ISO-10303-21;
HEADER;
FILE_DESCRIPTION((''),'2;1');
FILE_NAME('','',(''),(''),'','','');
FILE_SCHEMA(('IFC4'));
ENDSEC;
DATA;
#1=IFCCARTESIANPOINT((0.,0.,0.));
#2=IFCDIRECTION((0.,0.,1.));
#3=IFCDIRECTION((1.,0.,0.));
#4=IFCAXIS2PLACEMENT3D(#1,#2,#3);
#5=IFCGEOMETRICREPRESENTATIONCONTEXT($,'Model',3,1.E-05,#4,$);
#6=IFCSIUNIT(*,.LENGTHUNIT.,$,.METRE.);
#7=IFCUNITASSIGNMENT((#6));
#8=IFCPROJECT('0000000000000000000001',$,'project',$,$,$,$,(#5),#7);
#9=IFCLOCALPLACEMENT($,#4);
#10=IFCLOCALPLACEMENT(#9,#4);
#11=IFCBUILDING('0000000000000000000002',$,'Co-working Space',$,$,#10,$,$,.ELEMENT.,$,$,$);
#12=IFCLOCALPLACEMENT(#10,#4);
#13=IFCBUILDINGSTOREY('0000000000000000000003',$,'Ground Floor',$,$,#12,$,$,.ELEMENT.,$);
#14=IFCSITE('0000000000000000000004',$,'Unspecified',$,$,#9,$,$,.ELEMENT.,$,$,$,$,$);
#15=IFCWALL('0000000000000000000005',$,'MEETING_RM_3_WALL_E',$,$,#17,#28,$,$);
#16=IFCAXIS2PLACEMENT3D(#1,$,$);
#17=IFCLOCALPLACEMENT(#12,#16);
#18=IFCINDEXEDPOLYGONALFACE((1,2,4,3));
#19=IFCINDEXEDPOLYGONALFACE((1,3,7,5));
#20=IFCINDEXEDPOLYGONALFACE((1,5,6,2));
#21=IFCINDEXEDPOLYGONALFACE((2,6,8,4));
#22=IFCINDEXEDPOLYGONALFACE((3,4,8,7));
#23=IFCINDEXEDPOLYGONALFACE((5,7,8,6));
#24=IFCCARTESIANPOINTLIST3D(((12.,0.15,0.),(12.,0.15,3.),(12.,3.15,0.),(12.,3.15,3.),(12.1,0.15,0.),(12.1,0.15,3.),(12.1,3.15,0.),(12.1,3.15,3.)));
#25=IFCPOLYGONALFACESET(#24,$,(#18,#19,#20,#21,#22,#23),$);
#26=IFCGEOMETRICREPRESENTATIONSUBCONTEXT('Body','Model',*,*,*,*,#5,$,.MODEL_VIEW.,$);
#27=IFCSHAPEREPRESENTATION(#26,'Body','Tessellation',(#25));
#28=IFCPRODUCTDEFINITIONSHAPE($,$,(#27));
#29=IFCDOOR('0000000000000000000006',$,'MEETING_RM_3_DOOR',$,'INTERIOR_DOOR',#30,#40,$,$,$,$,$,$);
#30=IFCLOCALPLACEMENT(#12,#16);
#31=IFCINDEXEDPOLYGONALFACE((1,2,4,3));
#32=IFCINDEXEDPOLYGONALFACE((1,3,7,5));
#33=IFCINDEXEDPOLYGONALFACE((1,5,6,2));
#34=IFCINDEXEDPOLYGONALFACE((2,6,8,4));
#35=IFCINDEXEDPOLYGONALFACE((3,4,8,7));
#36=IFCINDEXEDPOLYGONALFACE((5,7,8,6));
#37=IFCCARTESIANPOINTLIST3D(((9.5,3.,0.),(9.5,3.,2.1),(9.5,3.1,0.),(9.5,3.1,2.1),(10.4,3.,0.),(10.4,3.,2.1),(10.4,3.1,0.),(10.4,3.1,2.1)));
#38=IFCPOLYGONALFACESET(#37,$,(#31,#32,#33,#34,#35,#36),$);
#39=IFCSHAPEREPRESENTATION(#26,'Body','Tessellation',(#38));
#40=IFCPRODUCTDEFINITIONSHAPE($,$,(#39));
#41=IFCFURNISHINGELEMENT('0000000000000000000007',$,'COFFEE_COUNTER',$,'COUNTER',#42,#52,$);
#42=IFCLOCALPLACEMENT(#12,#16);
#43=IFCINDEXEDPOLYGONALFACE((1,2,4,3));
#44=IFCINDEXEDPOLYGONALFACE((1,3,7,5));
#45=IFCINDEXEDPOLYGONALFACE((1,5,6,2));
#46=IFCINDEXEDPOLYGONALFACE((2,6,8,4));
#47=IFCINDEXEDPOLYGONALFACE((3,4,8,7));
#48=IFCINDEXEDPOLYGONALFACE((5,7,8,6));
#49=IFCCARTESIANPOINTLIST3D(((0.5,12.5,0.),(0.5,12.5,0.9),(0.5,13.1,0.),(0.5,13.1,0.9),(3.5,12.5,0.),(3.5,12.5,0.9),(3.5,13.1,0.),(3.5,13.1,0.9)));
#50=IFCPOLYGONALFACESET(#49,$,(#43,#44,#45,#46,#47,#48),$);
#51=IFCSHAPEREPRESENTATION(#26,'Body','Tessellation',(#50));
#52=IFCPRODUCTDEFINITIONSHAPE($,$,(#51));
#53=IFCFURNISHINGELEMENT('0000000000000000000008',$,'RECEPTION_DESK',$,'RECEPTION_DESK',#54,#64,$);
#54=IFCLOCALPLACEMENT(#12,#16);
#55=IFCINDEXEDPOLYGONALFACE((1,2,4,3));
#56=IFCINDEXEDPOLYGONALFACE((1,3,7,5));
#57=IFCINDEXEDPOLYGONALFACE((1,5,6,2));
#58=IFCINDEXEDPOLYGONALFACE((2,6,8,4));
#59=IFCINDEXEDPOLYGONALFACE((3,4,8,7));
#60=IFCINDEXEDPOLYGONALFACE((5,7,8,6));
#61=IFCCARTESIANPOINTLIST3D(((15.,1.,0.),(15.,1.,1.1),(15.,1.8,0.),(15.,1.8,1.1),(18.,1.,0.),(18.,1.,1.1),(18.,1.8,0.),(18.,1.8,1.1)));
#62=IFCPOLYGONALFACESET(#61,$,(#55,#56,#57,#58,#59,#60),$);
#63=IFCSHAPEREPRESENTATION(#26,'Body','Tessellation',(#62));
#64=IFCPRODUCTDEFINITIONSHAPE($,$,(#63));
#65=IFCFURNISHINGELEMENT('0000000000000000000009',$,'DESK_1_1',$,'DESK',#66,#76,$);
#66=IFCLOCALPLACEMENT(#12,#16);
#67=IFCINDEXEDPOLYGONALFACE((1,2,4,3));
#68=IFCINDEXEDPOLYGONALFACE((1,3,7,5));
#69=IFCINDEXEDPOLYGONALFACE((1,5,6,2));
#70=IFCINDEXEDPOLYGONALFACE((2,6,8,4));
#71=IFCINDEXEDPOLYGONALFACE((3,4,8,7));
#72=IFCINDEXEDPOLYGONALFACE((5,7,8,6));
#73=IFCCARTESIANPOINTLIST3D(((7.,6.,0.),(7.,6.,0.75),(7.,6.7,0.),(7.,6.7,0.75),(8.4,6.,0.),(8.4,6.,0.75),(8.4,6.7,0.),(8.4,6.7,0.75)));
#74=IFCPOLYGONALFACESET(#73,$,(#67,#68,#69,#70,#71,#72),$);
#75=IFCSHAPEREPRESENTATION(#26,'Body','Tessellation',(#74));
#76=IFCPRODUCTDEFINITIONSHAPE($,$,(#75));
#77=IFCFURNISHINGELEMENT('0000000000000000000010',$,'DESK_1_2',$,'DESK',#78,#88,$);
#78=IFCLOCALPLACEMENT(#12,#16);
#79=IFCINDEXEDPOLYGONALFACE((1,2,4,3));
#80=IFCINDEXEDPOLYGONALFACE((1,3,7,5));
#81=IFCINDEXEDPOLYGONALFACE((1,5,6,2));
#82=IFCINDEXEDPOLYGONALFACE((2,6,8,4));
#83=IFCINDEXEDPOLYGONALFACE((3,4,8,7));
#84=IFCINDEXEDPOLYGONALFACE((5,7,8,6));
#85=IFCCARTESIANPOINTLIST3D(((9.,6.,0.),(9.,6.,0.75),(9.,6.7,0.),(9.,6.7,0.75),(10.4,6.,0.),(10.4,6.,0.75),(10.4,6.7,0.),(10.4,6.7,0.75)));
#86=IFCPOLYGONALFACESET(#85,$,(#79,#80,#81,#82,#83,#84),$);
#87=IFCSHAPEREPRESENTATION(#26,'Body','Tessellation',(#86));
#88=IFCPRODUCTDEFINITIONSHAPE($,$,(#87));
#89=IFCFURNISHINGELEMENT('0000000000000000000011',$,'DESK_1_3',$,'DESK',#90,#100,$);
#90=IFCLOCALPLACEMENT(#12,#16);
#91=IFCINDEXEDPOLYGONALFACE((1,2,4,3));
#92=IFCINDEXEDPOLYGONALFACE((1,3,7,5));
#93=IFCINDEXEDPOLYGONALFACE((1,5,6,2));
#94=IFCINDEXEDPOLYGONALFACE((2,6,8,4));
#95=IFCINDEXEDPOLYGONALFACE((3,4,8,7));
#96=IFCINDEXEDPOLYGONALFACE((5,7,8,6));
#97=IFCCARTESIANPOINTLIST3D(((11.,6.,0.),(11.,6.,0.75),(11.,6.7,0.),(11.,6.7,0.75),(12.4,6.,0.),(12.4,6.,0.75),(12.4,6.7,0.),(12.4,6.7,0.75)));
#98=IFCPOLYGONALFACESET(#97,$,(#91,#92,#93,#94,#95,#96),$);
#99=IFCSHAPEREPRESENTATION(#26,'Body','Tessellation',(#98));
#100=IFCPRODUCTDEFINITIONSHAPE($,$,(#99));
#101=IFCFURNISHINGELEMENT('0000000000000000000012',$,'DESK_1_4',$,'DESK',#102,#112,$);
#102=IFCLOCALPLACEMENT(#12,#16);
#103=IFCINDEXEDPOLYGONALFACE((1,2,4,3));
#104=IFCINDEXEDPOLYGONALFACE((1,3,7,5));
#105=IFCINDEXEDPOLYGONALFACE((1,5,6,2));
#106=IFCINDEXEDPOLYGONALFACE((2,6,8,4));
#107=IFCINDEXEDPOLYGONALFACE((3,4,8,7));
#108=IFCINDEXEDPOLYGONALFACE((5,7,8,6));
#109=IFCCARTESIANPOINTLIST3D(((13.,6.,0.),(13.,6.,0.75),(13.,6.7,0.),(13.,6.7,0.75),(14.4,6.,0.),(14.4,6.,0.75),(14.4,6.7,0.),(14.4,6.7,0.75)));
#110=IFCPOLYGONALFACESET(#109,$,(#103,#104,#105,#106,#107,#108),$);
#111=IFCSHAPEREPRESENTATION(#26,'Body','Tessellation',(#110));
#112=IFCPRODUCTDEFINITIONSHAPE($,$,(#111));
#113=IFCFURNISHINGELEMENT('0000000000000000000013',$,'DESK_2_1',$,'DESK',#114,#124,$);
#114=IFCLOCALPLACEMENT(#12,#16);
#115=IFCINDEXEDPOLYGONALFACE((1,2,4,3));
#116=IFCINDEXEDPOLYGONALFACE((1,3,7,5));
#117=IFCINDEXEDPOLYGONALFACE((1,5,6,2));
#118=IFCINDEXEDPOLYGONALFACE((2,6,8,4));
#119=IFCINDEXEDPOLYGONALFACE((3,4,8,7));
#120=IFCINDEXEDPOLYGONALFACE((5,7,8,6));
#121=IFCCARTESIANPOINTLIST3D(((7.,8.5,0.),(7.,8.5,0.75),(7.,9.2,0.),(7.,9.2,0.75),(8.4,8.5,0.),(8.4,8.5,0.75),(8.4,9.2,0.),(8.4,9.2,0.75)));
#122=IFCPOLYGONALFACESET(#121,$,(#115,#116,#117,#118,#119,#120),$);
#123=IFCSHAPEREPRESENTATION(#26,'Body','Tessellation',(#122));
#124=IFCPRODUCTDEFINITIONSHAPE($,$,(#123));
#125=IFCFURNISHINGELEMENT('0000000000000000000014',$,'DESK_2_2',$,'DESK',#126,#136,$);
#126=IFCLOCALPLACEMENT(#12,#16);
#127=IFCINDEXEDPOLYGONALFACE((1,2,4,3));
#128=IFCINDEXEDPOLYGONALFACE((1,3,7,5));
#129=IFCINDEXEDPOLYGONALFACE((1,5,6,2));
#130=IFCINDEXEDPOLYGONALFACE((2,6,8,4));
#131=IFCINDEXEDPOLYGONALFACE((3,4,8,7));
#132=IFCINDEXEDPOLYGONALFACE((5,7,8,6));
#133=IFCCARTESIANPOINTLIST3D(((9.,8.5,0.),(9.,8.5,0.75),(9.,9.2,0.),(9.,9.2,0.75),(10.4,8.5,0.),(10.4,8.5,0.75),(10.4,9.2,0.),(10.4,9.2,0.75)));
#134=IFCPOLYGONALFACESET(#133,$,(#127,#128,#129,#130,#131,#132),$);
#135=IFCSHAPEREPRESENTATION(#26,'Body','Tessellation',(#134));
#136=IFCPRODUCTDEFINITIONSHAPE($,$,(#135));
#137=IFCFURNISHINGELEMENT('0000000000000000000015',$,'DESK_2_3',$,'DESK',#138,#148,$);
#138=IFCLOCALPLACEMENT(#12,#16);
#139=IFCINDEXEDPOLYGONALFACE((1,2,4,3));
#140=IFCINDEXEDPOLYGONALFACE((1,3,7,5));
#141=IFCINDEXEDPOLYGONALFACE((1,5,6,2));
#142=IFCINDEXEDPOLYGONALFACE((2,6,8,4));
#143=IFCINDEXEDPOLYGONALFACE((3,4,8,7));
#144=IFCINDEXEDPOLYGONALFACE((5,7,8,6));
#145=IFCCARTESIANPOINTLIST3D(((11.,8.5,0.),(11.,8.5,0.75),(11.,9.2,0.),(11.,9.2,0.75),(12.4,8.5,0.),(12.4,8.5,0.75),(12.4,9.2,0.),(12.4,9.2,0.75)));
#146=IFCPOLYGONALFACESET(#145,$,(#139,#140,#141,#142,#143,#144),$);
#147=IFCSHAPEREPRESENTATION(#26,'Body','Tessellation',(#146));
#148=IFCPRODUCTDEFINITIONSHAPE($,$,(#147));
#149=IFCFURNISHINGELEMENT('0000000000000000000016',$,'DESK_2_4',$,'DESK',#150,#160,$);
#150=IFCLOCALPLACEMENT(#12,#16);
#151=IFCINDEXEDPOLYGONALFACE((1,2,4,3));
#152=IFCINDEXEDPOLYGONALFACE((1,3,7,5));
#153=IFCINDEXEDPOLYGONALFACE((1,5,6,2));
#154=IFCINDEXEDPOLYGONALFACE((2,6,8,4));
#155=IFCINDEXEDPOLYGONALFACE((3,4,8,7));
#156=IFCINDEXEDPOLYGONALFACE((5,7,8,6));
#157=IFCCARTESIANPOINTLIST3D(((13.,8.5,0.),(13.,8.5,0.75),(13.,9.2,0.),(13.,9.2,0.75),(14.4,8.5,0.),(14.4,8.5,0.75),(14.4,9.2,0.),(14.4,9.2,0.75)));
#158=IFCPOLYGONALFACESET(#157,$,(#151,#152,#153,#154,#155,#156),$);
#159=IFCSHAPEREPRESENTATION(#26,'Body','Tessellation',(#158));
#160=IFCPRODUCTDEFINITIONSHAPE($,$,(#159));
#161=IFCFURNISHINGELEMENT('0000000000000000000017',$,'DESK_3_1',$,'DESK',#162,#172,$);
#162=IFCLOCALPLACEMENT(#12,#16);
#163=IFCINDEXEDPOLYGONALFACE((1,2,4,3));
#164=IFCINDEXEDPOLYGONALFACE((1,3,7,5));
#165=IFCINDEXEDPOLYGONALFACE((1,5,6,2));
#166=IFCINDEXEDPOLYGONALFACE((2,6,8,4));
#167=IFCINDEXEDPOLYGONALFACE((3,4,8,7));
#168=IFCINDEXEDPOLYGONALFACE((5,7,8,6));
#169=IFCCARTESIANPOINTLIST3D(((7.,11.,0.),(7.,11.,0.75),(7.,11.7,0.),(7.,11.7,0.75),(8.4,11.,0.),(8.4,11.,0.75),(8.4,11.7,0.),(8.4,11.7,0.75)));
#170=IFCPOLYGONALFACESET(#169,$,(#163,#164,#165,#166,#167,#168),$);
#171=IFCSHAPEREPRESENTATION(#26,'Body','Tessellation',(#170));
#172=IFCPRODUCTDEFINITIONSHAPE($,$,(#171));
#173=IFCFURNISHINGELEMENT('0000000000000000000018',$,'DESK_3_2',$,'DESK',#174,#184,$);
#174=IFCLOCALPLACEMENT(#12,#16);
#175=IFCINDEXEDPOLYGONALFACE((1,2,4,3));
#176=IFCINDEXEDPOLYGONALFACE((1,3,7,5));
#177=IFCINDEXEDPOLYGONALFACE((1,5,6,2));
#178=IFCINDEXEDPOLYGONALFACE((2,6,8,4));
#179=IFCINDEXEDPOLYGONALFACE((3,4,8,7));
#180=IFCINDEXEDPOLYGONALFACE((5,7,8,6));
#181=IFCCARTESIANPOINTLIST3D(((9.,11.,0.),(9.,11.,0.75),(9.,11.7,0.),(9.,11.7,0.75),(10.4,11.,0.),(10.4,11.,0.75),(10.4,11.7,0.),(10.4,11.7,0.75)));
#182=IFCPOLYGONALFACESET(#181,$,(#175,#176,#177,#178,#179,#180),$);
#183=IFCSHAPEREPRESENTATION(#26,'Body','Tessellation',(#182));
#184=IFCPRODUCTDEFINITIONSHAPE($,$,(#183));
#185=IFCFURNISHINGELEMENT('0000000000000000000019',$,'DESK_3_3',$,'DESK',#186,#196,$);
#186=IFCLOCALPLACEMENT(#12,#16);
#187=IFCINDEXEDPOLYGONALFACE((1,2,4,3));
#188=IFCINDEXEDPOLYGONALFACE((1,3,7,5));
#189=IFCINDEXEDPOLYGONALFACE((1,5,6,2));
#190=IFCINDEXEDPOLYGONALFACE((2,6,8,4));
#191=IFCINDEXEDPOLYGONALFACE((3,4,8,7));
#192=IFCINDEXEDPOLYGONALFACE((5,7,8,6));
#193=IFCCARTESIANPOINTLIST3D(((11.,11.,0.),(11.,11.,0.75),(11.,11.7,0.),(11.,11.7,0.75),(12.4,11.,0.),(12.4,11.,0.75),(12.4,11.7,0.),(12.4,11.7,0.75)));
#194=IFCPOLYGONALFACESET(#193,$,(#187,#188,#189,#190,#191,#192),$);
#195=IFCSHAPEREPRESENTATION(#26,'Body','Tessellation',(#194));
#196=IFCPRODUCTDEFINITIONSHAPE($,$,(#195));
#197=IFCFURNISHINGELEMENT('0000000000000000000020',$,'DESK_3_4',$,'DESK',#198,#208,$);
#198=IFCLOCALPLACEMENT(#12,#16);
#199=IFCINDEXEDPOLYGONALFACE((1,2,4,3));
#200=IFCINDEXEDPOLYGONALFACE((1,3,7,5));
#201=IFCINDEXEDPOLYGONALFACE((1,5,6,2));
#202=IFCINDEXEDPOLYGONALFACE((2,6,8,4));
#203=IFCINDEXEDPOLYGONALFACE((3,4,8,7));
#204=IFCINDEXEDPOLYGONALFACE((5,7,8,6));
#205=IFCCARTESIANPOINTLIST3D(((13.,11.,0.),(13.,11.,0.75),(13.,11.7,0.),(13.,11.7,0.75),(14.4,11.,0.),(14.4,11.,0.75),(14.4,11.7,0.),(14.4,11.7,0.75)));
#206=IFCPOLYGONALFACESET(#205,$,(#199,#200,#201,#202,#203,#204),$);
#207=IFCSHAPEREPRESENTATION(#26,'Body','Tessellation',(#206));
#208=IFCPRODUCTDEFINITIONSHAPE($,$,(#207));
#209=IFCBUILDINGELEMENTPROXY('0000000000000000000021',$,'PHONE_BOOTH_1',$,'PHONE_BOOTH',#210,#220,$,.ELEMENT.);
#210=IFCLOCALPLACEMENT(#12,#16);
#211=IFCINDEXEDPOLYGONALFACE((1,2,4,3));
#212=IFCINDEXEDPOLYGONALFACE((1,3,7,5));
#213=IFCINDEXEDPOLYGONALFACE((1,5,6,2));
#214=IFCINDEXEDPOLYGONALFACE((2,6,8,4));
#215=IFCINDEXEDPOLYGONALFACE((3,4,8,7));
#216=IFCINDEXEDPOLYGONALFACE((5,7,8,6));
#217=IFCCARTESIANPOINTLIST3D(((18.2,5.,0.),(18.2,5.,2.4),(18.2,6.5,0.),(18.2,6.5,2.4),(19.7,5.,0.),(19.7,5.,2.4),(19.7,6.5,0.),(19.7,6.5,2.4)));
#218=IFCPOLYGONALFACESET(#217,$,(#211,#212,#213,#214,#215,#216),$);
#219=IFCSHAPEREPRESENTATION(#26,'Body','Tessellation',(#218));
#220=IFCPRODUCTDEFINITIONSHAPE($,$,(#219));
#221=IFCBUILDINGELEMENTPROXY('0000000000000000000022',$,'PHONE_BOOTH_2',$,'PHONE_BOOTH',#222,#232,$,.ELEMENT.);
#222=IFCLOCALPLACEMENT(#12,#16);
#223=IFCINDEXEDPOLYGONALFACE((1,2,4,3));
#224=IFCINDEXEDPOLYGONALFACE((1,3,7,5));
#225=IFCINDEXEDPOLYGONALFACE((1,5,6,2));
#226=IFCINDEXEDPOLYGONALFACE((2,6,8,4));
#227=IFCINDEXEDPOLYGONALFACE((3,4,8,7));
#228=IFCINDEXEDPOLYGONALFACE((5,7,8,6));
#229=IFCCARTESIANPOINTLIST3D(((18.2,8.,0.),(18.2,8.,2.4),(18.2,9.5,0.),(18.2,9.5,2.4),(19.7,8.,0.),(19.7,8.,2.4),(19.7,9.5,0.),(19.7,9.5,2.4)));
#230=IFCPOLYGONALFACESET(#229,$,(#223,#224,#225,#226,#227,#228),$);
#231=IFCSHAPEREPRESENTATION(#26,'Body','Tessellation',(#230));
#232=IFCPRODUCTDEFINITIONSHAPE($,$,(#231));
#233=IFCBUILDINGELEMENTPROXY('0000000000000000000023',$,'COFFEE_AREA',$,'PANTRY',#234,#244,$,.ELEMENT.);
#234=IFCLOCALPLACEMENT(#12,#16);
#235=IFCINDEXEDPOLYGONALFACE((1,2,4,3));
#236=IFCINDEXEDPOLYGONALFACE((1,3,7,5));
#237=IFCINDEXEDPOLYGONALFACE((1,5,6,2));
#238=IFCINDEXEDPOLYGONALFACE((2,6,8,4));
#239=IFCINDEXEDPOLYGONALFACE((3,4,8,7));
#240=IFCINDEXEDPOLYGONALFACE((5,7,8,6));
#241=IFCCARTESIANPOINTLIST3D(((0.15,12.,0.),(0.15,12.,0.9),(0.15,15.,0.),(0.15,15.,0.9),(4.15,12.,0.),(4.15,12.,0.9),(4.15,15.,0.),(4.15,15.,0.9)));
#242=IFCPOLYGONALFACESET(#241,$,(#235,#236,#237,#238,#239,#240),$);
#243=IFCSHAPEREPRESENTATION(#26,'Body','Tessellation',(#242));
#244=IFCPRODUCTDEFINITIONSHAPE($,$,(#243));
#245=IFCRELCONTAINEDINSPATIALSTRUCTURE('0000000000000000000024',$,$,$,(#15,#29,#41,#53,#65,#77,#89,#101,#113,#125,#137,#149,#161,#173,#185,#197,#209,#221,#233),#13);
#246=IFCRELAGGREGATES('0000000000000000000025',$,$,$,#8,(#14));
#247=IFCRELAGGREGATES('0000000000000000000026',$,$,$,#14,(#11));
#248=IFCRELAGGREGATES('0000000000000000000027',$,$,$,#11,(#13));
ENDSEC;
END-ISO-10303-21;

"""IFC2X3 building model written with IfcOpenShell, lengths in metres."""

from ifc_helpers import new_model, si_unit, frame, frame_2d, origin, origin_with_axes, place, context, subcontext, project, spatial, rectangle, extrude, element, save


model = new_model("IFC2X3")

# Units and contexts
model_context = context("Model", 3, precision=1e-05, world=origin_with_axes())
body_context = subcontext(model_context, "Body", "Model", "MODEL_VIEW")
ifc_project = project(units=[si_unit("LENGTHUNIT", "METRE")], contexts=[model_context])

# Site, building, storey
site_placement = place(None, origin_with_axes())
site = spatial("IfcSite", under=ifc_project, at=site_placement, Name="Unspecified", CompositionType="ELEMENT")
building_placement = place(site_placement, origin_with_axes())
building = spatial("IfcBuilding", under=site, at=building_placement, Name="Co-working Space", CompositionType="ELEMENT")
storey_placement = place(building_placement, origin_with_axes())
storey = spatial("IfcBuildingStorey", under=building, at=storey_placement, Name="Ground Floor", CompositionType="ELEMENT")

# Wall
wall_1_placement = place(storey_placement, frame((12.0, 0.15, 0.0), z_axis=(0.0, 0.0, 1.0), x_axis=(1.0, 0.0, 0.0)))
element("IfcWall", 1, at=wall_1_placement, inside=storey, Name="MEETING_RM_3_WALL_E", context=body_context, shape_type="SweptSolid", body=[
    extrude(rectangle(XDim=0.1, YDim=3.0, at=frame_2d((0.05, 1.5))), origin(), (0.0, 0.0, 1.0), 3.0),
])

# Door
door_1_placement = place(storey_placement, frame((9.5, 3.0, 0.0), z_axis=(0.0, 0.0, 1.0), x_axis=(1.0, 0.0, 0.0)))
element("IfcDoor", 2, at=door_1_placement, inside=storey, Name="MEETING_RM_3_DOOR", ObjectType="INTERIOR_DOOR", context=body_context, shape_type="SweptSolid", body=[
    extrude(rectangle(XDim=0.9, YDim=0.1, at=frame_2d((0.45, 0.05))), origin(), (0.0, 0.0, 1.0), 2.1),
])

# Furnishing elements
furnishing_1_placement = place(storey_placement, frame((0.5, 12.5, 0.0), z_axis=(0.0, 0.0, 1.0), x_axis=(1.0, 0.0, 0.0)))
element("IfcFurnishingElement", 3, at=furnishing_1_placement, inside=storey, Name="COFFEE_COUNTER", ObjectType="COUNTER", context=body_context, shape_type="SweptSolid", body=[
    extrude(rectangle(XDim=3.0, YDim=0.6, at=frame_2d((1.5, 0.3))), origin(), (0.0, 0.0, 1.0), 0.9),
])
furnishing_2_placement = place(storey_placement, frame((15.0, 1.0, 0.0), z_axis=(0.0, 0.0, 1.0), x_axis=(1.0, 0.0, 0.0)))
element("IfcFurnishingElement", 4, at=furnishing_2_placement, inside=storey, Name="RECEPTION_DESK", ObjectType="RECEPTION_DESK", context=body_context, shape_type="SweptSolid", body=[
    extrude(rectangle(XDim=3.0, YDim=0.8, at=frame_2d((1.5, 0.4))), origin(), (0.0, 0.0, 1.0), 1.1),
])
for number, where, z_axis, x_axis, name in (
    (5, (7.0, 6.0, 0.0), (0.0, 0.0, 1.0), (1.0, 0.0, 0.0), "DESK_1_1"),
    (6, (9.0, 6.0, 0.0), (0.0, 0.0, 1.0), (1.0, 0.0, 0.0), "DESK_1_2"),
    (7, (11.0, 6.0, 0.0), (0.0, 0.0, 1.0), (1.0, 0.0, 0.0), "DESK_1_3"),
    (8, (13.0, 6.0, 0.0), (0.0, 0.0, 1.0), (1.0, 0.0, 0.0), "DESK_1_4"),
    (9, (7.0, 8.5, 0.0), (0.0, 0.0, 1.0), (1.0, 0.0, 0.0), "DESK_2_1"),
    (10, (9.0, 8.5, 0.0), (0.0, 0.0, 1.0), (1.0, 0.0, 0.0), "DESK_2_2"),
    (11, (11.0, 8.5, 0.0), (0.0, 0.0, 1.0), (1.0, 0.0, 0.0), "DESK_2_3"),
    (12, (13.0, 8.5, 0.0), (0.0, 0.0, 1.0), (1.0, 0.0, 0.0), "DESK_2_4"),
    (13, (7.0, 11.0, 0.0), (0.0, 0.0, 1.0), (1.0, 0.0, 0.0), "DESK_3_1"),
    (14, (9.0, 11.0, 0.0), (0.0, 0.0, 1.0), (1.0, 0.0, 0.0), "DESK_3_2"),
    (15, (11.0, 11.0, 0.0), (0.0, 0.0, 1.0), (1.0, 0.0, 0.0), "DESK_3_3"),
    (16, (13.0, 11.0, 0.0), (0.0, 0.0, 1.0), (1.0, 0.0, 0.0), "DESK_3_4"),
):
    element("IfcFurnishingElement", number, at=place(storey_placement, frame(where, z_axis=z_axis, x_axis=x_axis)), inside=storey, Name=name, ObjectType="DESK", context=body_context, shape_type="SweptSolid", body=[
        extrude(rectangle(XDim=1.4, YDim=0.7, at=frame_2d((0.7, 0.35))), origin(), (0.0, 0.0, 1.0), 0.75),
    ])

# Building element proxies
for number, where, z_axis, x_axis, name in (
    (17, (18.2, 5.0, 0.0), (0.0, 0.0, 1.0), (1.0, 0.0, 0.0), "PHONE_BOOTH_1"),
    (18, (18.2, 8.0, 0.0), (0.0, 0.0, 1.0), (1.0, 0.0, 0.0), "PHONE_BOOTH_2"),
):
    element("IfcBuildingElementProxy", number, at=place(storey_placement, frame(where, z_axis=z_axis, x_axis=x_axis)), inside=storey, Name=name, ObjectType="PHONE_BOOTH", CompositionType="ELEMENT", context=body_context, shape_type="SweptSolid", body=[
        extrude(rectangle(XDim=1.5, YDim=1.5, at=frame_2d((0.75, 0.75))), origin(), (0.0, 0.0, 1.0), 2.4),
    ])
proxy_placement = place(storey_placement, frame((0.15, 12.0, 0.0), z_axis=(0.0, 0.0, 1.0), x_axis=(1.0, 0.0, 0.0)))
element("IfcBuildingElementProxy", 19, at=proxy_placement, inside=storey, Name="COFFEE_AREA", ObjectType="PANTRY", CompositionType="ELEMENT", context=body_context, shape_type="SweptSolid", body=[
    extrude(rectangle(XDim=4.0, YDim=3.0, at=frame_2d((2.0, 1.5))), origin(), (0.0, 0.0, 1.0), 0.9),
])

save(model, "model.ifc")
